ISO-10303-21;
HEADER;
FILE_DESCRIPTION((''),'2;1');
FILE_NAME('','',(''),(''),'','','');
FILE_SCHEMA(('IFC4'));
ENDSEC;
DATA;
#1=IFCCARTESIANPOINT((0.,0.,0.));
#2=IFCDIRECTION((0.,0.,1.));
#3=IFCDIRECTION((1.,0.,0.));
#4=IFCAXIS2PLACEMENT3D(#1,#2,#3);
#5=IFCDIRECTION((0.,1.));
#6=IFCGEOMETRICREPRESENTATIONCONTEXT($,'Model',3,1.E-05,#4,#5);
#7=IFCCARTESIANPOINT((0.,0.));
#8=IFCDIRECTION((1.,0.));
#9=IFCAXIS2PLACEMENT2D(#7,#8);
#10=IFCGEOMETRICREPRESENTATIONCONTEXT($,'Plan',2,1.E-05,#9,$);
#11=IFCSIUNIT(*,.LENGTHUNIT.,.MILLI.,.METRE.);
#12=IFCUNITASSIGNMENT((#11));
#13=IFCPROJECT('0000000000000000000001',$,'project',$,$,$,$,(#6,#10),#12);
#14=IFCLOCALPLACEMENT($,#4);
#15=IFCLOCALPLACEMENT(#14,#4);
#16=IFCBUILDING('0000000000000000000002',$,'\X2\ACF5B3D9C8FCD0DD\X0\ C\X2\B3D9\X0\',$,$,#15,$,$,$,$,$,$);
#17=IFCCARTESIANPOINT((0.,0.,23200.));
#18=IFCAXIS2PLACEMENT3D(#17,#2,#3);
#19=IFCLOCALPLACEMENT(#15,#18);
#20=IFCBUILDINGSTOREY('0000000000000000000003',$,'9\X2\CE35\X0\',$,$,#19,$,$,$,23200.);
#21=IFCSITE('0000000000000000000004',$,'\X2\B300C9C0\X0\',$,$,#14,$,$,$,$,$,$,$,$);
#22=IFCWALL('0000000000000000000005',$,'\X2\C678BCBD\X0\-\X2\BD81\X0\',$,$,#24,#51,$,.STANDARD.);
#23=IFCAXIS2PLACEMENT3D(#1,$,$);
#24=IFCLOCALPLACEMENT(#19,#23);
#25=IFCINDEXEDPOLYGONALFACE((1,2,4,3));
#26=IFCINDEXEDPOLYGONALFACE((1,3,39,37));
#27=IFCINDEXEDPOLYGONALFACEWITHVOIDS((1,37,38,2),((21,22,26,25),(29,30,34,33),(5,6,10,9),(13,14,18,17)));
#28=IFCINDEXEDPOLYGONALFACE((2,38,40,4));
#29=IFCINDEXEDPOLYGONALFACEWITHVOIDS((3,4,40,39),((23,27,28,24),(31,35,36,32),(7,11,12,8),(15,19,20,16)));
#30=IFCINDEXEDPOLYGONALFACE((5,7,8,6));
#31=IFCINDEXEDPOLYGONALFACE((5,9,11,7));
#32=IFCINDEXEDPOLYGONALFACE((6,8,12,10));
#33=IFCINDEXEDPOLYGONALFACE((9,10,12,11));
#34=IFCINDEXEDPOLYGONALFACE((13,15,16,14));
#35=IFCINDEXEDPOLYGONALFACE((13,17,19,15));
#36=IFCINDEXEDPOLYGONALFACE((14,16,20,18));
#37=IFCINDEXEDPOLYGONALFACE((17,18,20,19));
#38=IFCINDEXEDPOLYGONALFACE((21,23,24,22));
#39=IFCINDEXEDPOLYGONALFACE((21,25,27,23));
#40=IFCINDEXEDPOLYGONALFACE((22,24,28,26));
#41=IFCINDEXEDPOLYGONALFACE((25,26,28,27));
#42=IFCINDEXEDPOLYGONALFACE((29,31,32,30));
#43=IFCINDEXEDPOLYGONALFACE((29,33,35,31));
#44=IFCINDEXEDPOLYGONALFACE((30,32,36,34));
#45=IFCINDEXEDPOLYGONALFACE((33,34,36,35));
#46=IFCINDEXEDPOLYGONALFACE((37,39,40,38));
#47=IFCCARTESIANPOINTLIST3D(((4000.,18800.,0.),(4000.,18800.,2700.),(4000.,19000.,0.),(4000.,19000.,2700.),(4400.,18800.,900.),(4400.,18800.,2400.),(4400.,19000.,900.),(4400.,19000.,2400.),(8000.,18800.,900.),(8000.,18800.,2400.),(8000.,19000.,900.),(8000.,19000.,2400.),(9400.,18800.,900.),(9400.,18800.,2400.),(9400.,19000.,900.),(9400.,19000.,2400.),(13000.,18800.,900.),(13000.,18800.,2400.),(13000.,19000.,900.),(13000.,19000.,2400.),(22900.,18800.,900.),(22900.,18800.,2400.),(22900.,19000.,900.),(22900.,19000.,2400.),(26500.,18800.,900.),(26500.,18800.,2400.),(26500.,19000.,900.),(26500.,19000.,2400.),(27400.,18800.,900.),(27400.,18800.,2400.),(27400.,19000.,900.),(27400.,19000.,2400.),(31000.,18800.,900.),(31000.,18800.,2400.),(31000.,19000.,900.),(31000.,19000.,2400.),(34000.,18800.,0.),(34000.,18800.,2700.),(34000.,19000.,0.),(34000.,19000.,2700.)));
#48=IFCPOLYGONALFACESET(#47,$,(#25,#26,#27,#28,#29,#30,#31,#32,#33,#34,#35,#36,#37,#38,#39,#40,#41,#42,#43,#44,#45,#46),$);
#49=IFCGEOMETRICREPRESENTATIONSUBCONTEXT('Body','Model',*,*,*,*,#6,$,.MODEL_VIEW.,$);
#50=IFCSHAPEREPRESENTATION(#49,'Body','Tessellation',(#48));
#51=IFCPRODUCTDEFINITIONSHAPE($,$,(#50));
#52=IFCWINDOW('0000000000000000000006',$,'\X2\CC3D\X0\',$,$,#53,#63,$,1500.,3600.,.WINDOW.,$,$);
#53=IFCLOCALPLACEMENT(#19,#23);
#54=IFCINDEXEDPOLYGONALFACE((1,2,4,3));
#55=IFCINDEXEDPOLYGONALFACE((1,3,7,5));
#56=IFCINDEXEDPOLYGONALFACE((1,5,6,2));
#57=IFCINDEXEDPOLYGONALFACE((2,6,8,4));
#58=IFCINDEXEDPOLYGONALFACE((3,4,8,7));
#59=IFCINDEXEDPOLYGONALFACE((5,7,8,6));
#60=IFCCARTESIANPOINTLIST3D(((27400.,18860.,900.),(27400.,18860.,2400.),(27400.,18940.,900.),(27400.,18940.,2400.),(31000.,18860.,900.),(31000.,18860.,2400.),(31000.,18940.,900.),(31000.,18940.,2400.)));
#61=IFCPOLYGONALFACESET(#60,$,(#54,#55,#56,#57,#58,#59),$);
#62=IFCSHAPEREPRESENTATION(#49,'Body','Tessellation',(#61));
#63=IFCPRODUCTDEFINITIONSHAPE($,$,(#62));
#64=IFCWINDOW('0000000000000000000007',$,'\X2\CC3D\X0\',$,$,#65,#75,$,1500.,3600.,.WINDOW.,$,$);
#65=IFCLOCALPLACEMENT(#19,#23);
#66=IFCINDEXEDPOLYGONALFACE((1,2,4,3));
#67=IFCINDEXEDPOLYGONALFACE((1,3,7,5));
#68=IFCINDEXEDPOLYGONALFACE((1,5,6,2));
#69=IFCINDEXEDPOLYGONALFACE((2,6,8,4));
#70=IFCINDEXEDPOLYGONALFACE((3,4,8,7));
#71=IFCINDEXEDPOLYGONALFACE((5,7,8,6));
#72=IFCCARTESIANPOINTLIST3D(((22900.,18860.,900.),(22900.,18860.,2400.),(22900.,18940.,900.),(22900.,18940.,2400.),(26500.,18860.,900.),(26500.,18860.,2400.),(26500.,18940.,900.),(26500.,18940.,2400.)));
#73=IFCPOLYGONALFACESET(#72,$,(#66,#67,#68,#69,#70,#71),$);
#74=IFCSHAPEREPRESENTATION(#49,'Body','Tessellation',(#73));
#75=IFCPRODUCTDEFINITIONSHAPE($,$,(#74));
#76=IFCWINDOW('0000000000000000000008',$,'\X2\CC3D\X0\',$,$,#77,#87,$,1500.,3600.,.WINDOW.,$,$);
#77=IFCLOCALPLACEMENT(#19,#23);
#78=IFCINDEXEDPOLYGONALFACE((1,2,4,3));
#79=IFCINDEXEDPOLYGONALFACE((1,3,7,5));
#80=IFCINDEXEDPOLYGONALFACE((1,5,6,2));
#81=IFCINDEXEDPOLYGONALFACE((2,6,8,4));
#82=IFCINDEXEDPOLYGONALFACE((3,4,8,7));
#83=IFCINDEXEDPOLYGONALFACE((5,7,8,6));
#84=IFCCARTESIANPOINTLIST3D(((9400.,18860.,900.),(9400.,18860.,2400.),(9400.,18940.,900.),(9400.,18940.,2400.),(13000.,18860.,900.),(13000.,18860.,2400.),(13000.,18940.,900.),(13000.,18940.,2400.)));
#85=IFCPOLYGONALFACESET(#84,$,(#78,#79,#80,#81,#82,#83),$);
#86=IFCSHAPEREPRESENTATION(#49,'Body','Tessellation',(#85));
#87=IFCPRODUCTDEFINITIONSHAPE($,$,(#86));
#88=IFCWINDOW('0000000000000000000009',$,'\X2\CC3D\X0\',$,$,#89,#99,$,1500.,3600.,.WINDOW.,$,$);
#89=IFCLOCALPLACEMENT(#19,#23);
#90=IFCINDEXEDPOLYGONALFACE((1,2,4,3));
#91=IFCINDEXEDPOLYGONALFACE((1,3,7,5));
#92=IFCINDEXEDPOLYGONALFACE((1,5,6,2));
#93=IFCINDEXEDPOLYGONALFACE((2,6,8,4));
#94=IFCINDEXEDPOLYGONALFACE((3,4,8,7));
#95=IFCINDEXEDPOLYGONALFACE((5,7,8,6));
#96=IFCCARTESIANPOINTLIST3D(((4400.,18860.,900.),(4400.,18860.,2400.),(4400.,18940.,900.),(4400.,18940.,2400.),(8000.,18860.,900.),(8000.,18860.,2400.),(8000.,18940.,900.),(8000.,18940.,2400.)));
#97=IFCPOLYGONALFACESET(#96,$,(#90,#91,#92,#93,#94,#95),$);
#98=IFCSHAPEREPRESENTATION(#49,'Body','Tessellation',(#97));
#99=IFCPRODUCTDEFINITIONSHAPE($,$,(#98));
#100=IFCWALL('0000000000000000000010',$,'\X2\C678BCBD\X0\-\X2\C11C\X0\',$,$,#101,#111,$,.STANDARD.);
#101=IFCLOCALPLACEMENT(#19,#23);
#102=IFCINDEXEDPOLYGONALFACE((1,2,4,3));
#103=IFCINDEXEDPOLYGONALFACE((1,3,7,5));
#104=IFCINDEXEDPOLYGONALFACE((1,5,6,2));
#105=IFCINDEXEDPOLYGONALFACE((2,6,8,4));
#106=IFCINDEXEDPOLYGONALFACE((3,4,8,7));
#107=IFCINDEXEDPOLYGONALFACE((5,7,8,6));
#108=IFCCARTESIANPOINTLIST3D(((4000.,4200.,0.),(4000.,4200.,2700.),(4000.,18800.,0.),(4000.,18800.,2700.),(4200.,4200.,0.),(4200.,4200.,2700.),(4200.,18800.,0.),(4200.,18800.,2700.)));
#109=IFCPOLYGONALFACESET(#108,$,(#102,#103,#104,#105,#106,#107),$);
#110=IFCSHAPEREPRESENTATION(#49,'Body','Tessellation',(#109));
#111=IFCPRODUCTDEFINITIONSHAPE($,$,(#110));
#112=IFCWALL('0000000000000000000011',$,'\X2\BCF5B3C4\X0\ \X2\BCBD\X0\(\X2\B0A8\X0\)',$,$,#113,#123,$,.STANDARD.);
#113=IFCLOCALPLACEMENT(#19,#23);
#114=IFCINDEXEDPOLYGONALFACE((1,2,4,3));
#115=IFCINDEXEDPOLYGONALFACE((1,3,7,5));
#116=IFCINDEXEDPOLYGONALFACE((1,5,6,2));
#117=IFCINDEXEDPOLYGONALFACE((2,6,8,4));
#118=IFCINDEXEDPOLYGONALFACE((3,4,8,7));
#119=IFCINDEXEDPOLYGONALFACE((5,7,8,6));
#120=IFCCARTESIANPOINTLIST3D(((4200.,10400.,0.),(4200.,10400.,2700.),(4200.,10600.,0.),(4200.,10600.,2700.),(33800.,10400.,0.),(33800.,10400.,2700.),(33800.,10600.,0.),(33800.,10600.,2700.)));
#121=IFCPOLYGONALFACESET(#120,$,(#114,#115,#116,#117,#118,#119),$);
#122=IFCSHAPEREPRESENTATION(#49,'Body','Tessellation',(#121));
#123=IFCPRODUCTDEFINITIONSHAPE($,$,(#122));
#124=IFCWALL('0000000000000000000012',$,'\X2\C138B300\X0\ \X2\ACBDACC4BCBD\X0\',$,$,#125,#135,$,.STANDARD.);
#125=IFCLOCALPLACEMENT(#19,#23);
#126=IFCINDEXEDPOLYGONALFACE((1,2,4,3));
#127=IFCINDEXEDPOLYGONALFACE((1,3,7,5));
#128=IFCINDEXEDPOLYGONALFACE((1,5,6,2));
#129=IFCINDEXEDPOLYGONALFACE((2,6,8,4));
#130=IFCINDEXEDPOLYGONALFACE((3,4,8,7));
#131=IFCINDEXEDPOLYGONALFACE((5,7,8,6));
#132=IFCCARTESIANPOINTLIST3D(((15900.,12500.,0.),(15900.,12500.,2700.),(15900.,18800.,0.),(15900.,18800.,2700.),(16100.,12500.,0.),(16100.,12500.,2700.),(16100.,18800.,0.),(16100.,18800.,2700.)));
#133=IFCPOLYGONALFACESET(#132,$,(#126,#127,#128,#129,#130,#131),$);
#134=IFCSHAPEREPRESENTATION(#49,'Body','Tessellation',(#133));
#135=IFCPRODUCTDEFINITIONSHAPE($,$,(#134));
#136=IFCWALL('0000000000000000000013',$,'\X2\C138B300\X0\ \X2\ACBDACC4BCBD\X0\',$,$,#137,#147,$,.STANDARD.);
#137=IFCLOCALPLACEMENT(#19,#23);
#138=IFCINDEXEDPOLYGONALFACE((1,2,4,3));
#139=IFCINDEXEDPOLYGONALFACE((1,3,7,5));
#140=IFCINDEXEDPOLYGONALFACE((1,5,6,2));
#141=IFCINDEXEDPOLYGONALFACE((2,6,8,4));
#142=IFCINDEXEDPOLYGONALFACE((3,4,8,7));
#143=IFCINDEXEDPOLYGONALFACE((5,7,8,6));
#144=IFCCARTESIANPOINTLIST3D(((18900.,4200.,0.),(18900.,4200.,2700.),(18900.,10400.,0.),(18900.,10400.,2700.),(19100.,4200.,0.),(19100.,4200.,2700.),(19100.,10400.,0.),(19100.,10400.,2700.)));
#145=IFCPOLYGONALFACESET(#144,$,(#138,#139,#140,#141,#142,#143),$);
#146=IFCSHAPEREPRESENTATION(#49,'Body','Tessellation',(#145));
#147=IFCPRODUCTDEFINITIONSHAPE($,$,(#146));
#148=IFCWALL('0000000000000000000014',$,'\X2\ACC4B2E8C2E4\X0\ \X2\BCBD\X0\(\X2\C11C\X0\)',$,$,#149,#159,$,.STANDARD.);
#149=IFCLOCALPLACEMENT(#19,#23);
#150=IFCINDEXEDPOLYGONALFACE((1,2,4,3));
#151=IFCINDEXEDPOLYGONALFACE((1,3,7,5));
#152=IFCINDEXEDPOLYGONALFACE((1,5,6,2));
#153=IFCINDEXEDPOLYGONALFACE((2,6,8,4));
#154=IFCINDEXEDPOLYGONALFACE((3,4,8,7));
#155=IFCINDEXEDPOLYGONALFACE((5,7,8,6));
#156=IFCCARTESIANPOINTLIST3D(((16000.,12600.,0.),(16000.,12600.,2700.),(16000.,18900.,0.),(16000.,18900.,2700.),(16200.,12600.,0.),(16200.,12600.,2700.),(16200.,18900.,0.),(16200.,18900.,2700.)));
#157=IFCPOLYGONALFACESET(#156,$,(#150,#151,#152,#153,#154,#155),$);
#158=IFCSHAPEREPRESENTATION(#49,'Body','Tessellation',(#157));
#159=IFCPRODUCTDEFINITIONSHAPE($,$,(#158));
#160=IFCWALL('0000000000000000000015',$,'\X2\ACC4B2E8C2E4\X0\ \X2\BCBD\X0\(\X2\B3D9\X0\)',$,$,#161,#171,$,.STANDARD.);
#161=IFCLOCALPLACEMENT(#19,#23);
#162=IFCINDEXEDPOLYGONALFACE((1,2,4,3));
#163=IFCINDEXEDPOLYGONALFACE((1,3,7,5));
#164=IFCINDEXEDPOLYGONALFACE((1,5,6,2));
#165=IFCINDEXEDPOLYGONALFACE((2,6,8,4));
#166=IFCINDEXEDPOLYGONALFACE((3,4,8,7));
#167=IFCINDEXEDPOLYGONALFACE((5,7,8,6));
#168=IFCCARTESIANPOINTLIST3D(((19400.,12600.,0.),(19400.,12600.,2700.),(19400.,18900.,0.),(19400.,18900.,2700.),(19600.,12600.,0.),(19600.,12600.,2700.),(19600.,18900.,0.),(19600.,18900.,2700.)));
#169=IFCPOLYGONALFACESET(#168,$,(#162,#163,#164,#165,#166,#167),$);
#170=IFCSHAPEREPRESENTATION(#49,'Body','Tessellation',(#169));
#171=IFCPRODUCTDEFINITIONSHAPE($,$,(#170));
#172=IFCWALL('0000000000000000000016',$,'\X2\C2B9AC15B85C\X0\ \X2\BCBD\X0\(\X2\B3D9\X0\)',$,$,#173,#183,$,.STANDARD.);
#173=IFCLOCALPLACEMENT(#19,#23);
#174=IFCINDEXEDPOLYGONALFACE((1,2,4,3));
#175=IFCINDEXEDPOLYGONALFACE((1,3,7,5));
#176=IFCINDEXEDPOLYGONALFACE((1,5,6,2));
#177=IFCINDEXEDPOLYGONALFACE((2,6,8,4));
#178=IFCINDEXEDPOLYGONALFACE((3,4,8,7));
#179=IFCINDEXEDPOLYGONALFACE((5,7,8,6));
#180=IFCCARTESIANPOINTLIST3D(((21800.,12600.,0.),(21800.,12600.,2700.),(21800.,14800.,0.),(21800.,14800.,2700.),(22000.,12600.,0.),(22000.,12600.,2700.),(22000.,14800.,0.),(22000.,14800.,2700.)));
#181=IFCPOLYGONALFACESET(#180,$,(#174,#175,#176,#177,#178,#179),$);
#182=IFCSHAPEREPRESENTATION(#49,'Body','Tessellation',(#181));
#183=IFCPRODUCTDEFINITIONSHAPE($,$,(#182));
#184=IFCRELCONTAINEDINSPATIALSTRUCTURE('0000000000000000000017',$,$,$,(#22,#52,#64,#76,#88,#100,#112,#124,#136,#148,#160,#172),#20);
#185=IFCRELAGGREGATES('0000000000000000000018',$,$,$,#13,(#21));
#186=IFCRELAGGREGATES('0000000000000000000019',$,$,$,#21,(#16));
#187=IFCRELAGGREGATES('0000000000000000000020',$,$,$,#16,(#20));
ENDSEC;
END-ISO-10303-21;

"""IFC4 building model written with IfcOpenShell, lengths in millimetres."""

from ifc_helpers import new_model, si_unit, direction, frame, origin_with_axes, origin_2d_with_axis, place, context, subcontext, project, spatial, polyline, outline, extrude, element, fill, save


model = new_model("IFC4")

# Units and contexts
model_context = context("Model", 3, precision=1e-05, world=origin_with_axes(), true_north=direction((0.0, 1.0)))
plan_context = context("Plan", 2, precision=1e-05, world=origin_2d_with_axis())
body_context = subcontext(model_context, "Body", "Model", "MODEL_VIEW")
ifc_project = project(units=[si_unit("LENGTHUNIT", "METRE", prefix="MILLI")], contexts=[model_context, plan_context])

# Site, building, storey
site_placement = place(None, origin_with_axes())
site = spatial("IfcSite", under=ifc_project, at=site_placement, Name="대지")
building_placement = place(site_placement, origin_with_axes())
building = spatial("IfcBuilding", under=site, at=building_placement, Name="공동주택 C동")
storey_placement = place(building_placement, frame((0.0, 0.0, 23200.0), z_axis=(0.0, 0.0, 1.0), x_axis=(1.0, 0.0, 0.0)))
storey = spatial("IfcBuildingStorey", under=building, at=storey_placement, Name="9층", Elevation=23200.0)

# Wall, openings, windows
wall_1_placement = place(storey_placement, origin_with_axes())
wall_1 = element("IfcWall", 1, at=wall_1_placement, inside=storey, Name="외벽-북", PredefinedType="STANDARD", context=body_context, shape_type="SweptSolid", body=[
    extrude(outline(polyline([(34000.0, 18800.0), (4000.0, 18800.0), (4000.0, 19000.0), (34000.0, 19000.0), (34000.0, 18800.0)])), origin_with_axes(), (0.0, 0.0, 1.0), 2700.0),
])
opening_1_placement = place(storey_placement, origin_with_axes())
opening_1 = element("IfcOpeningElement", 2, at=opening_1_placement, cuts=wall_1, PredefinedType="OPENING", context=body_context, shape_type="SweptSolid", body=[
    extrude(outline(polyline([(31000.0, 19050.0), (27400.0, 19050.0), (27400.0, 18750.0), (31000.0, 18750.0), (31000.0, 19050.0)])), frame((0.0, 0.0, 900.0), z_axis=(0.0, 0.0, 1.0), x_axis=(1.0, 0.0, 0.0)), (0.0, 0.0, 1.0), 1500.0),
])
opening_2_placement = place(storey_placement, origin_with_axes())
opening_2 = element("IfcOpeningElement", 3, at=opening_2_placement, cuts=wall_1, PredefinedType="OPENING", context=body_context, shape_type="SweptSolid", body=[
    extrude(outline(polyline([(26500.0, 19050.0), (22900.0, 19050.0), (22900.0, 18750.0), (26500.0, 18750.0), (26500.0, 19050.0)])), frame((0.0, 0.0, 900.0), z_axis=(0.0, 0.0, 1.0), x_axis=(1.0, 0.0, 0.0)), (0.0, 0.0, 1.0), 1500.0),
])
opening_3_placement = place(storey_placement, origin_with_axes())
opening_3 = element("IfcOpeningElement", 4, at=opening_3_placement, cuts=wall_1, PredefinedType="OPENING", context=body_context, shape_type="SweptSolid", body=[
    extrude(outline(polyline([(13000.0, 19050.0), (9400.0, 19050.0), (9400.0, 18750.0), (13000.0, 18750.0), (13000.0, 19050.0)])), frame((0.0, 0.0, 900.0), z_axis=(0.0, 0.0, 1.0), x_axis=(1.0, 0.0, 0.0)), (0.0, 0.0, 1.0), 1500.0),
])
opening_4_placement = place(storey_placement, origin_with_axes())
opening_4 = element("IfcOpeningElement", 5, at=opening_4_placement, cuts=wall_1, PredefinedType="OPENING", context=body_context, shape_type="SweptSolid", body=[
    extrude(outline(polyline([(8000.0, 19050.0), (4400.0, 19050.0), (4400.0, 18750.0), (8000.0, 18750.0), (8000.0, 19050.0)])), frame((0.0, 0.0, 900.0), z_axis=(0.0, 0.0, 1.0), x_axis=(1.0, 0.0, 0.0)), (0.0, 0.0, 1.0), 1500.0),
])
window_1_placement = place(storey_placement, origin_with_axes())
window_1 = element("IfcWindow", 6, at=window_1_placement, inside=storey, Name="창", OverallHeight=1500.0, OverallWidth=3600.0, PredefinedType="WINDOW", context=body_context, shape_type="SweptSolid", body=[
    extrude(outline(polyline([(31000.0, 18940.0), (27400.0, 18940.0), (27400.0, 18860.0), (31000.0, 18860.0), (31000.0, 18940.0)])), frame((0.0, 0.0, 900.0), z_axis=(0.0, 0.0, 1.0), x_axis=(1.0, 0.0, 0.0)), (0.0, 0.0, 1.0), 1500.0),
])
fill(opening_1, window_1)
window_2_placement = place(storey_placement, origin_with_axes())
window_2 = element("IfcWindow", 7, at=window_2_placement, inside=storey, Name="창", OverallHeight=1500.0, OverallWidth=3600.0, PredefinedType="WINDOW", context=body_context, shape_type="SweptSolid", body=[
    extrude(outline(polyline([(26500.0, 18940.0), (22900.0, 18940.0), (22900.0, 18860.0), (26500.0, 18860.0), (26500.0, 18940.0)])), frame((0.0, 0.0, 900.0), z_axis=(0.0, 0.0, 1.0), x_axis=(1.0, 0.0, 0.0)), (0.0, 0.0, 1.0), 1500.0),
])
fill(opening_2, window_2)
window_3_placement = place(storey_placement, origin_with_axes())
window_3 = element("IfcWindow", 8, at=window_3_placement, inside=storey, Name="창", OverallHeight=1500.0, OverallWidth=3600.0, PredefinedType="WINDOW", context=body_context, shape_type="SweptSolid", body=[
    extrude(outline(polyline([(13000.0, 18940.0), (9400.0, 18940.0), (9400.0, 18860.0), (13000.0, 18860.0), (13000.0, 18940.0)])), frame((0.0, 0.0, 900.0), z_axis=(0.0, 0.0, 1.0), x_axis=(1.0, 0.0, 0.0)), (0.0, 0.0, 1.0), 1500.0),
])
fill(opening_3, window_3)
window_4_placement = place(storey_placement, origin_with_axes())
window_4 = element("IfcWindow", 9, at=window_4_placement, inside=storey, Name="창", OverallHeight=1500.0, OverallWidth=3600.0, PredefinedType="WINDOW", context=body_context, shape_type="SweptSolid", body=[
    extrude(outline(polyline([(8000.0, 18940.0), (4400.0, 18940.0), (4400.0, 18860.0), (8000.0, 18860.0), (8000.0, 18940.0)])), frame((0.0, 0.0, 900.0), z_axis=(0.0, 0.0, 1.0), x_axis=(1.0, 0.0, 0.0)), (0.0, 0.0, 1.0), 1500.0),
])
fill(opening_4, window_4)

# Walls
wall_2_placement = place(storey_placement, origin_with_axes())
element("IfcWall", 10, at=wall_2_placement, inside=storey, Name="외벽-서", PredefinedType="STANDARD", context=body_context, shape_type="SweptSolid", body=[
    extrude(outline(polyline([(4200.0, 18800.0), (4200.0, 4200.0), (4000.0, 4200.0), (4000.0, 18800.0), (4200.0, 18800.0)])), origin_with_axes(), (0.0, 0.0, 1.0), 2700.0),
])
wall_3_placement = place(storey_placement, origin_with_axes())
element("IfcWall", 11, at=wall_3_placement, inside=storey, Name="복도 벽(남)", PredefinedType="STANDARD", context=body_context, shape_type="SweptSolid", body=[
    extrude(outline(polyline([(4200.0, 10600.0), (33800.0, 10600.0), (33800.0, 10400.0), (4200.0, 10400.0), (4200.0, 10600.0)])), origin_with_axes(), (0.0, 0.0, 1.0), 2700.0),
])
wall_4_placement = place(storey_placement, origin_with_axes())
element("IfcWall", 12, at=wall_4_placement, inside=storey, Name="세대 경계벽", PredefinedType="STANDARD", context=body_context, shape_type="SweptSolid", body=[
    extrude(outline(polyline([(15900.0, 12500.0), (15900.0, 18800.0), (16100.0, 18800.0), (16100.0, 12500.0), (15900.0, 12500.0)])), origin_with_axes(), (0.0, 0.0, 1.0), 2700.0),
])
wall_5_placement = place(storey_placement, origin_with_axes())
element("IfcWall", 13, at=wall_5_placement, inside=storey, Name="세대 경계벽", PredefinedType="STANDARD", context=body_context, shape_type="SweptSolid", body=[
    extrude(outline(polyline([(18900.0, 4200.0), (18900.0, 10400.0), (19100.0, 10400.0), (19100.0, 4200.0), (18900.0, 4200.0)])), origin_with_axes(), (0.0, 0.0, 1.0), 2700.0),
])
wall_6_placement = place(storey_placement, origin_with_axes())
element("IfcWall", 14, at=wall_6_placement, inside=storey, Name="계단실 벽(서)", PredefinedType="STANDARD", context=body_context, shape_type="SweptSolid", body=[
    extrude(outline(polyline([(16000.0, 12600.0), (16000.0, 18900.0), (16200.0, 18900.0), (16200.0, 12600.0), (16000.0, 12600.0)])), origin_with_axes(), (0.0, 0.0, 1.0), 2700.0),
])
wall_7_placement = place(storey_placement, origin_with_axes())
element("IfcWall", 15, at=wall_7_placement, inside=storey, Name="계단실 벽(동)", PredefinedType="STANDARD", context=body_context, shape_type="SweptSolid", body=[
    extrude(outline(polyline([(19400.0, 12600.0), (19400.0, 18900.0), (19600.0, 18900.0), (19600.0, 12600.0), (19400.0, 12600.0)])), origin_with_axes(), (0.0, 0.0, 1.0), 2700.0),
])
wall_8_placement = place(storey_placement, origin_with_axes())
element("IfcWall", 16, at=wall_8_placement, inside=storey, Name="승강로 벽(동)", PredefinedType="STANDARD", context=body_context, shape_type="SweptSolid", body=[
    extrude(outline(polyline([(21800.0, 12600.0), (21800.0, 14800.0), (22000.0, 14800.0), (22000.0, 12600.0), (21800.0, 12600.0)])), origin_with_axes(), (0.0, 0.0, 1.0), 2700.0),
])

save(model, "model.ifc")
